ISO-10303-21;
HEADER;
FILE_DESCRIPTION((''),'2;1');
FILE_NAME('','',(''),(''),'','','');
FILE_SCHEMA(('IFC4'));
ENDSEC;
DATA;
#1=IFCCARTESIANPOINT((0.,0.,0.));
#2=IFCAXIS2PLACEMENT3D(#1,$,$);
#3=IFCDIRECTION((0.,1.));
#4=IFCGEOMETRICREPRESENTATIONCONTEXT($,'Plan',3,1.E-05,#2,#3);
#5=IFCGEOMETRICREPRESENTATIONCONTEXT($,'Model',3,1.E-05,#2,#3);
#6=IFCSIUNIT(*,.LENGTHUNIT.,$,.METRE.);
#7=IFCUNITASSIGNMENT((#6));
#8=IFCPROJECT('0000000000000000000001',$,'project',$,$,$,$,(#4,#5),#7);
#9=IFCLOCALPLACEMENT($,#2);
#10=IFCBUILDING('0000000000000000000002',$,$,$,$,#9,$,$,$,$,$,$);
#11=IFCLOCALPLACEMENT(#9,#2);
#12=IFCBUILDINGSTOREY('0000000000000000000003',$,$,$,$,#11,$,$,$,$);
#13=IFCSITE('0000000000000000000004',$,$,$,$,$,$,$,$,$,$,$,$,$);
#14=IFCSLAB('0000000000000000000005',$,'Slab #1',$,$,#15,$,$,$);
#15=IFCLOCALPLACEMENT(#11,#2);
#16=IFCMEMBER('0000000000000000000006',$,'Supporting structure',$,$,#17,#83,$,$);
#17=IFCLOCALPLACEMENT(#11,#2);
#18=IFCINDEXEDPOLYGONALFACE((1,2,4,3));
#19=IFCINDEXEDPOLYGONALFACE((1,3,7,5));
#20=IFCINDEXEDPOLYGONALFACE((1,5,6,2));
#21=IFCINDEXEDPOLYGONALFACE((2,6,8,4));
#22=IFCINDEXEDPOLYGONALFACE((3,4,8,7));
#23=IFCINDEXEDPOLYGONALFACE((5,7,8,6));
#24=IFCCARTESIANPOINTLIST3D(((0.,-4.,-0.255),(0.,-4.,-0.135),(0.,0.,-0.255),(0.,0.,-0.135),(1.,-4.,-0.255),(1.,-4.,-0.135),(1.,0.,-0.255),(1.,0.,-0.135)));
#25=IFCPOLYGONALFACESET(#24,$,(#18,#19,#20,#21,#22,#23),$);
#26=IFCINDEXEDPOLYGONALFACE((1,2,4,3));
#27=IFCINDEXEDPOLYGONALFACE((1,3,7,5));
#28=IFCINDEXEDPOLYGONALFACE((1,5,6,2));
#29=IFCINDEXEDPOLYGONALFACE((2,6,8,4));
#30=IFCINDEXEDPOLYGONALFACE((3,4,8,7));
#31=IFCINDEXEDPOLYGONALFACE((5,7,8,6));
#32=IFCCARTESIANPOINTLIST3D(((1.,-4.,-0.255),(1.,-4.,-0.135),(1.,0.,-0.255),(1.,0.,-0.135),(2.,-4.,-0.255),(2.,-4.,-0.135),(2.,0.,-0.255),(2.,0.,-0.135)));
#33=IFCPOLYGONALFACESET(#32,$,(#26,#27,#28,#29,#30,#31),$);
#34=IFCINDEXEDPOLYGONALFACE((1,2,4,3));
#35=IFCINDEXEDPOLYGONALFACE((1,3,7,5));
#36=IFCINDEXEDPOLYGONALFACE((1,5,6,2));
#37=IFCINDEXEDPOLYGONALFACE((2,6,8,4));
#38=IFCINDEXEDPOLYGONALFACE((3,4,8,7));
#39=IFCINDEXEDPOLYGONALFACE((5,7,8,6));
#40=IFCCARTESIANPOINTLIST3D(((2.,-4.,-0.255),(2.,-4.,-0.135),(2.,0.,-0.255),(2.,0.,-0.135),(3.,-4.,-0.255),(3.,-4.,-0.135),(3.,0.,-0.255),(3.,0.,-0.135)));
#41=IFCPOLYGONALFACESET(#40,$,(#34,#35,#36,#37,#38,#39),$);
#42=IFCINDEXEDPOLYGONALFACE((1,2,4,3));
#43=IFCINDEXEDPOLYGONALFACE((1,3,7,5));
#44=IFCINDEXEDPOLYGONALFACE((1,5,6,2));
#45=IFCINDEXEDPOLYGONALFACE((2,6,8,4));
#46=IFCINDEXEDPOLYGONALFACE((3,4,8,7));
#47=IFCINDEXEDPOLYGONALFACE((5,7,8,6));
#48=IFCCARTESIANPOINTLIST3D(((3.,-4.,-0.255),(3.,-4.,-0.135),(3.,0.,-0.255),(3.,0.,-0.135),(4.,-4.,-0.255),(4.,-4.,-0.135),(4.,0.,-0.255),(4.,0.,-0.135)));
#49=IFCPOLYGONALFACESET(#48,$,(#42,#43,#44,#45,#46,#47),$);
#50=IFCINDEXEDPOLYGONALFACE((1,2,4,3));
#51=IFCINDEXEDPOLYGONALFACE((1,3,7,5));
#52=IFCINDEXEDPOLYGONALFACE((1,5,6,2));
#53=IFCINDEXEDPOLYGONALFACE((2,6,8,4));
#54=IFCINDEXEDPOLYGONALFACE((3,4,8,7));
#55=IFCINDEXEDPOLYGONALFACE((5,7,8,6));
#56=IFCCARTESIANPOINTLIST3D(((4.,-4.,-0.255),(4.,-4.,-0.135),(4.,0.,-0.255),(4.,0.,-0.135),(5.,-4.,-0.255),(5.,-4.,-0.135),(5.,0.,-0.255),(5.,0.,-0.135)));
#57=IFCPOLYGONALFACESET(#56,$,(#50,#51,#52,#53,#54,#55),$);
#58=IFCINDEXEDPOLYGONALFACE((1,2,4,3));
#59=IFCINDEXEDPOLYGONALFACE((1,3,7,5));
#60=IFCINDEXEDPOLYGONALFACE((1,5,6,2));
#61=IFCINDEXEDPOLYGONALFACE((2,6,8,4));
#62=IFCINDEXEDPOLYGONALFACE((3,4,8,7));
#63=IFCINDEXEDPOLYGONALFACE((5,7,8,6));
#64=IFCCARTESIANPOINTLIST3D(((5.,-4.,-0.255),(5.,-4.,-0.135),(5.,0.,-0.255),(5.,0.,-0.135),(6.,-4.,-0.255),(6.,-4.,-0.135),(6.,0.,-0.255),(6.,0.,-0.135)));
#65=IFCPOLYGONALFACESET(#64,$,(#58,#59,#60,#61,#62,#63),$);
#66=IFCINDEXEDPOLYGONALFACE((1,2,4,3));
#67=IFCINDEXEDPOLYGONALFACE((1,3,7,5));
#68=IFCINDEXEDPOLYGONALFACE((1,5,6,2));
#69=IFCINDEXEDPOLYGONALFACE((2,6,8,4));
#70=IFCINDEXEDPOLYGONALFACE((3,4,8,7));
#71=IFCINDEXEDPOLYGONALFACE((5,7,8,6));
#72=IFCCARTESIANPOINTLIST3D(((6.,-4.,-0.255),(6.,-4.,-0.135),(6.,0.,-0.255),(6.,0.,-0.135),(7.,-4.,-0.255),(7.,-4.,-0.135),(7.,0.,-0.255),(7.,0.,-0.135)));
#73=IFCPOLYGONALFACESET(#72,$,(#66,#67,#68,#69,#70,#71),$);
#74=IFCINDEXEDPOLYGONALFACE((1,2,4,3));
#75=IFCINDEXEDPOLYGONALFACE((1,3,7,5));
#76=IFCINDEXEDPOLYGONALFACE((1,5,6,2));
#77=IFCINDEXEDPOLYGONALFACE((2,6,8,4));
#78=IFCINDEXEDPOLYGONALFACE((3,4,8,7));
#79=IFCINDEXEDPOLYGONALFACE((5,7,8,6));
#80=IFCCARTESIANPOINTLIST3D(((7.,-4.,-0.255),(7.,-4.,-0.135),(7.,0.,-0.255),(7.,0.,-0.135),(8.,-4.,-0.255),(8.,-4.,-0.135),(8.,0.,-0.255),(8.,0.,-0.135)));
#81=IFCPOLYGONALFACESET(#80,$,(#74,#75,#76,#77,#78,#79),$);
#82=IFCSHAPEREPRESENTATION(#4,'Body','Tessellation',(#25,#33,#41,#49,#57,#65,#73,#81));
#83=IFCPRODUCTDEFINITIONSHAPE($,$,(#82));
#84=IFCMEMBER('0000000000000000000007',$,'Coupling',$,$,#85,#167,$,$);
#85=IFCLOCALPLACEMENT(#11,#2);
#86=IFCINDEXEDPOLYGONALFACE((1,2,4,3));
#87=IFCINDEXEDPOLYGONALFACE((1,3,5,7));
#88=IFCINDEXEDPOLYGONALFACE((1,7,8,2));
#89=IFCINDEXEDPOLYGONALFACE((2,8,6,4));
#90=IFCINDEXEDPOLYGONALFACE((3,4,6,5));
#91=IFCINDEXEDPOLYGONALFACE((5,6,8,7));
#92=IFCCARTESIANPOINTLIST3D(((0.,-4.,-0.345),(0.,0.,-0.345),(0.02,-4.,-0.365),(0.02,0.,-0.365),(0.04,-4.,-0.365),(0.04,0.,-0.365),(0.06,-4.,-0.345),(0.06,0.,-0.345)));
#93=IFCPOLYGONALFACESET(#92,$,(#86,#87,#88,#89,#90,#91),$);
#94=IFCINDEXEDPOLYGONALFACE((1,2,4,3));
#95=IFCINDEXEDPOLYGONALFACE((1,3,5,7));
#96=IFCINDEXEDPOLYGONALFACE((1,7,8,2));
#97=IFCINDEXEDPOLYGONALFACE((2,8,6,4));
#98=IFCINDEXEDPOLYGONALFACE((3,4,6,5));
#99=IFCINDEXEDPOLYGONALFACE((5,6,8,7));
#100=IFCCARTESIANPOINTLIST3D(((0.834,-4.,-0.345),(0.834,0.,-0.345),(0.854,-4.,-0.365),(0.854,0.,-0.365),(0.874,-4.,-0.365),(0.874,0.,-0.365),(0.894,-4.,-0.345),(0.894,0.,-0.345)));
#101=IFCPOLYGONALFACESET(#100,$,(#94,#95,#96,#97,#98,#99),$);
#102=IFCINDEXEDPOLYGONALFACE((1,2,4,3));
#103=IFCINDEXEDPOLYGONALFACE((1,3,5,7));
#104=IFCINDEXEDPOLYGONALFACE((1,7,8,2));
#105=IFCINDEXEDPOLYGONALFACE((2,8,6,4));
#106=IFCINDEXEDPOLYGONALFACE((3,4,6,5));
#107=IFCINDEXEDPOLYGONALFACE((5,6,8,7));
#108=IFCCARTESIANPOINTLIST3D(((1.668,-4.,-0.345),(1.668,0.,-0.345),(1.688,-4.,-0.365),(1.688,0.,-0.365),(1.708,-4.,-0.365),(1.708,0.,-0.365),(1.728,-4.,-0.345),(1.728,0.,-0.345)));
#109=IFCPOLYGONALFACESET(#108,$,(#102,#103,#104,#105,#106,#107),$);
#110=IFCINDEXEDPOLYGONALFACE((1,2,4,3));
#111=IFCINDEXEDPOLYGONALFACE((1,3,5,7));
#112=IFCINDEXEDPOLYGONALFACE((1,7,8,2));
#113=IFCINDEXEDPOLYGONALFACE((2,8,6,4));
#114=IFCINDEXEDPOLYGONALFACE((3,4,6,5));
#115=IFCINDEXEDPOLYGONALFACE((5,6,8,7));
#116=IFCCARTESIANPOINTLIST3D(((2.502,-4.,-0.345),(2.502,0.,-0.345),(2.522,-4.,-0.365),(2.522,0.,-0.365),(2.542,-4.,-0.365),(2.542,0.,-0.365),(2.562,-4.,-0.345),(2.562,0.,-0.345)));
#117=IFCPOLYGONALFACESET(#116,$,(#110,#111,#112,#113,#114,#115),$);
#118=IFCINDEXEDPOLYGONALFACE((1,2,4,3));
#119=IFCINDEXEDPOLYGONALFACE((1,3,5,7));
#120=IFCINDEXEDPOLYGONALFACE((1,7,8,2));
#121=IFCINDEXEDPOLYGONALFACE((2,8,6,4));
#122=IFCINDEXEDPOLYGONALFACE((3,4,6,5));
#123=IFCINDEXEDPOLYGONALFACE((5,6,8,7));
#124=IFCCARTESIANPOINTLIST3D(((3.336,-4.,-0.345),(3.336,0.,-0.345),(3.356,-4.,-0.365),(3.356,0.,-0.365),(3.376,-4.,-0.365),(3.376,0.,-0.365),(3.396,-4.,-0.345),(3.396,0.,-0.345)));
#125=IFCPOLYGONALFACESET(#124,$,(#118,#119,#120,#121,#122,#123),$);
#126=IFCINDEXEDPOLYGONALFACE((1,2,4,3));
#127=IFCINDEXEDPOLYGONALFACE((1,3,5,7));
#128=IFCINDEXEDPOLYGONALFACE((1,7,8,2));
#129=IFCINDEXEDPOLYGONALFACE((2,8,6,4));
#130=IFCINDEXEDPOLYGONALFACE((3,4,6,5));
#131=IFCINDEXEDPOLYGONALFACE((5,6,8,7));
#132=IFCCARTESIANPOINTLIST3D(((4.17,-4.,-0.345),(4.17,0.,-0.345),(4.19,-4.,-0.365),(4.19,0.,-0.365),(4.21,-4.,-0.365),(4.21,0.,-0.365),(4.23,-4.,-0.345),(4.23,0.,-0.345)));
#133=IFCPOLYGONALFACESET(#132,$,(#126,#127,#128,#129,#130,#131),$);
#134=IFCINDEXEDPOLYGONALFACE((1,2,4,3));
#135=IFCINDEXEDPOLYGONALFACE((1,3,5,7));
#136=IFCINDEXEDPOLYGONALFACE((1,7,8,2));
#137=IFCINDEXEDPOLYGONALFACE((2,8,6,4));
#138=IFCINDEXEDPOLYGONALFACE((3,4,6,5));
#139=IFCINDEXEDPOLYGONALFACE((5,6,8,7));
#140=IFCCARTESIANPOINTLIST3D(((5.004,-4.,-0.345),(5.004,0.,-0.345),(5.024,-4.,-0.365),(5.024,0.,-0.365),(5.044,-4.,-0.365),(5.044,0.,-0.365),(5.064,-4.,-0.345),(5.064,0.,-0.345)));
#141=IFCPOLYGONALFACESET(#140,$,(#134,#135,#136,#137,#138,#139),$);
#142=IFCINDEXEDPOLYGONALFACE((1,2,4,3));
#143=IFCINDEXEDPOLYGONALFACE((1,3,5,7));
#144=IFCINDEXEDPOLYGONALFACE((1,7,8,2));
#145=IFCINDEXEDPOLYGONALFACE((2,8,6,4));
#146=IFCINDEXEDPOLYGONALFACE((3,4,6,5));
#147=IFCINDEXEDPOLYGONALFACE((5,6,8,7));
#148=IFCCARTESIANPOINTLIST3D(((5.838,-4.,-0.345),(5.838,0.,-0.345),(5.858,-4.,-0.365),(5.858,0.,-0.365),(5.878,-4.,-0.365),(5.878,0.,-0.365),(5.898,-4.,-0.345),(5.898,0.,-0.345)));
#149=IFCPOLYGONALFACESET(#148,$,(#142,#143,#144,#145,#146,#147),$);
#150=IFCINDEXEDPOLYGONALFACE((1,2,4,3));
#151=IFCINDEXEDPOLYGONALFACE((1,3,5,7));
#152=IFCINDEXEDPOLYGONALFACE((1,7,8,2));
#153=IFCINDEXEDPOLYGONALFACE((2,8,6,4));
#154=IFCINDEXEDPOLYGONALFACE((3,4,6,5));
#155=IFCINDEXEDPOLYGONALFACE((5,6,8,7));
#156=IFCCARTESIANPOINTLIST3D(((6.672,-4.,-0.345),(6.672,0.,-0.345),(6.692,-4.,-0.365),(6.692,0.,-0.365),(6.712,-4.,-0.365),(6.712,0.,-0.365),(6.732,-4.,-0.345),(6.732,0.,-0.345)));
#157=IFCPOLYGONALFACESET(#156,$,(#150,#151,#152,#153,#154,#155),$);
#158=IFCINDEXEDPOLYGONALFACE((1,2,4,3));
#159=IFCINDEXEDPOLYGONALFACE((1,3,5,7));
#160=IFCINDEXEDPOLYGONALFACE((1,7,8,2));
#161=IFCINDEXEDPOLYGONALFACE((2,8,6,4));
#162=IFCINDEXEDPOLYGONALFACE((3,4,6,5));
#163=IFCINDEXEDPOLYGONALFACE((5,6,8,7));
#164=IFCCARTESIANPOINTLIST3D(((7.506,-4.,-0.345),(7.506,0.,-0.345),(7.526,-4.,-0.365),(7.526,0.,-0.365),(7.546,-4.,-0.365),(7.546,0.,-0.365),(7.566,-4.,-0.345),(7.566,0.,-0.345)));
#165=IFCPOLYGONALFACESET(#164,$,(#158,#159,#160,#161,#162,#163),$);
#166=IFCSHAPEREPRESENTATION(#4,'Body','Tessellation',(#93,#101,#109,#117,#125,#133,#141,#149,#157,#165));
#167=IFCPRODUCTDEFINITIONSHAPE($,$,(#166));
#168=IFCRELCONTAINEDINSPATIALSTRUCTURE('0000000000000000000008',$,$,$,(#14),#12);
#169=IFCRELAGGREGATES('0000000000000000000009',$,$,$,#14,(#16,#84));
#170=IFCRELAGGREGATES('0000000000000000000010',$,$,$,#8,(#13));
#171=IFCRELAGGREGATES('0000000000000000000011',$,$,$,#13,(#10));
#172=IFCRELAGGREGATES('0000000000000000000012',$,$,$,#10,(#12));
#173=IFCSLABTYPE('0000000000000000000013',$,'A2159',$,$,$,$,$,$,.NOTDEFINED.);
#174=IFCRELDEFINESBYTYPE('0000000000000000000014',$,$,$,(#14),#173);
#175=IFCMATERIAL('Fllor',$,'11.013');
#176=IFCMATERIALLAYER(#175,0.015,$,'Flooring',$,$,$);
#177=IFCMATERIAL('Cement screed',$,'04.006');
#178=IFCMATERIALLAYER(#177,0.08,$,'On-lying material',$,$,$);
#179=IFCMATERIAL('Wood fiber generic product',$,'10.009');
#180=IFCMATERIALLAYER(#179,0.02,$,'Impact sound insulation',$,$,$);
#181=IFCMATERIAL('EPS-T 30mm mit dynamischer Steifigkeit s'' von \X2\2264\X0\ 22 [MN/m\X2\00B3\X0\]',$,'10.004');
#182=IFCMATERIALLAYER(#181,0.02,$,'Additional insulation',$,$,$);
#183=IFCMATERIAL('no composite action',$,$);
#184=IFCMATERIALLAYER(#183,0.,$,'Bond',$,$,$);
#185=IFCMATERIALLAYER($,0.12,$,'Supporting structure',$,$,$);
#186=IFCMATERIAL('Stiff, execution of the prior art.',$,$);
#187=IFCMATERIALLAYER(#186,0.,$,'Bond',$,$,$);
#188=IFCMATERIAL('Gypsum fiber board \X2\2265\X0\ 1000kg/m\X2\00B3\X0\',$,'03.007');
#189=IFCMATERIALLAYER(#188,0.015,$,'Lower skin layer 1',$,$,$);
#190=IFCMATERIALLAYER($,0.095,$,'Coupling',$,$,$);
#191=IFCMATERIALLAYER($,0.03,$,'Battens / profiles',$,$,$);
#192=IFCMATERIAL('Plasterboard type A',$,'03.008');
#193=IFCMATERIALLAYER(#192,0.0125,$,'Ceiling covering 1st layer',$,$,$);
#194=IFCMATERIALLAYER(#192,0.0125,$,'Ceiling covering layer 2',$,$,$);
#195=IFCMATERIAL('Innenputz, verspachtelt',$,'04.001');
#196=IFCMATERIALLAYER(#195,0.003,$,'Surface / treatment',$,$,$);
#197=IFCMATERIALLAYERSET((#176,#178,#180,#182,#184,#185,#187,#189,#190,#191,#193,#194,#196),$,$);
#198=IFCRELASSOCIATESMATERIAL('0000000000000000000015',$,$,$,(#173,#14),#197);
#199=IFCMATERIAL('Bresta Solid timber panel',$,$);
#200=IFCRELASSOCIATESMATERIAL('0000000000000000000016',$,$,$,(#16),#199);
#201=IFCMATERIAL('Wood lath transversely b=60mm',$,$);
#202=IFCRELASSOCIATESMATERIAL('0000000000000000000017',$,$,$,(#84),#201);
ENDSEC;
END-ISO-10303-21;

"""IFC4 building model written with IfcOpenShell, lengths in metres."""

from ifc_helpers import new_model, si_unit, direction, frame, frame_2d, origin, place, context, project, spatial, polyline, rectangle, outline, extrude, material, layer, layer_set, type_object, element, aggregate, save


model = new_model("IFC4")

# Units and contexts
plan_context = context("Plan", 3, precision=1e-05, world=origin(), true_north=direction((0.0, 1.0)))
model_context = context("Model", 3, precision=1e-05, world=origin(), true_north=direction((0.0, 1.0)))
ifc_project = project(units=[si_unit("LENGTHUNIT", "METRE")], contexts=[plan_context, model_context])

# Site, building, storey
site = spatial("IfcSite", under=ifc_project)
building_placement = place(None, origin())
building = spatial("IfcBuilding", under=site, at=building_placement)
storey_placement = place(building_placement, origin())
storey = spatial("IfcBuildingStorey", under=building, at=storey_placement)

# Slab, members
ifc_material_1 = material(Name="Fllor", Category="11.013")
ifc_layer_1 = layer(ifc_material_1, 0.015, Name="Flooring")
ifc_material_2 = material(Name="Cement screed", Category="04.006")
ifc_layer_2 = layer(ifc_material_2, 0.08, Name="On-lying material")
ifc_material_3 = material(Name="Wood fiber generic product", Category="10.009")
ifc_layer_3 = layer(ifc_material_3, 0.02, Name="Impact sound insulation")
ifc_material_4 = material(Name="EPS-T 30mm mit dynamischer Steifigkeit s' von ≤ 22 [MN/m³]", Category="10.004")
ifc_layer_4 = layer(ifc_material_4, 0.02, Name="Additional insulation")
ifc_material_5 = material(Name="no composite action")
ifc_layer_5 = layer(ifc_material_5, 0.0, Name="Bond")
ifc_layer_6 = layer(None, 0.12, Name="Supporting structure")
ifc_material_6 = material(Name="Stiff, execution of the prior art.")
ifc_layer_7 = layer(ifc_material_6, 0.0, Name="Bond")
ifc_material_7 = material(Name="Gypsum fiber board ≥ 1000kg/m³", Category="03.007")
ifc_layer_8 = layer(ifc_material_7, 0.015, Name="Lower skin layer 1")
ifc_layer_9 = layer(None, 0.095, Name="Coupling")
ifc_layer_10 = layer(None, 0.03, Name="Battens / profiles")
ifc_material_8 = material(Name="Plasterboard type A", Category="03.008")
ifc_layer_11 = layer(ifc_material_8, 0.0125, Name="Ceiling covering 1st layer")
ifc_layer_12 = layer(ifc_material_8, 0.0125, Name="Ceiling covering layer 2")
ifc_material_9 = material(Name="Innenputz, verspachtelt", Category="04.001")
ifc_layer_13 = layer(ifc_material_9, 0.003, Name="Surface / treatment")
ifc_layer_set = layer_set([ifc_layer_1, ifc_layer_2, ifc_layer_3, ifc_layer_4, ifc_layer_5, ifc_layer_6, ifc_layer_7, ifc_layer_8, ifc_layer_9, ifc_layer_10, ifc_layer_11, ifc_layer_12, ifc_layer_13])
slab_type = type_object("IfcSlabType", Name="A2159", PredefinedType="NOTDEFINED", material=ifc_layer_set)
slab_placement = place(None, frame((0.0, 0.0, 0.0), z_axis=(0.0, 0.0, -1.0), x_axis=(1.0, 0.0, 0.0)))
slab = element("IfcSlab", 1, at=slab_placement, inside=storey, type_object=slab_type, material=ifc_layer_set, Name="Slab #1")
ifc_material_10 = material(Name="Bresta Solid timber panel")
member_1_placement = place(slab_placement, origin())
member_1 = element("IfcMember", 2, at=member_1_placement, material=ifc_material_10, Name="Supporting structure", context=plan_context, shape_type="SweptSolid", body=[
    extrude(rectangle(XDim=1.0, YDim=0.12, at=frame_2d((0.5, 0.06), x_axis=(1.0, 0.0))), frame((0.0, 4.0, 0.135), z_axis=(0.0, -1.0, 0.0), x_axis=(1.0, 0.0, 0.0)), (0.0, 0.0, 1.0), 4.0),
    extrude(rectangle(XDim=1.0, YDim=0.12, at=frame_2d((0.5, 0.06), x_axis=(1.0, 0.0))), frame((1.0, 4.0, 0.135), z_axis=(0.0, -1.0, 0.0), x_axis=(1.0, 0.0, 0.0)), (0.0, 0.0, 1.0), 4.0),
    extrude(rectangle(XDim=1.0, YDim=0.12, at=frame_2d((0.5, 0.06), x_axis=(1.0, 0.0))), frame((2.0, 4.0, 0.135), z_axis=(0.0, -1.0, 0.0), x_axis=(1.0, 0.0, 0.0)), (0.0, 0.0, 1.0), 4.0),
    extrude(rectangle(XDim=1.0, YDim=0.12, at=frame_2d((0.5, 0.06), x_axis=(1.0, 0.0))), frame((3.0, 4.0, 0.135), z_axis=(0.0, -1.0, 0.0), x_axis=(1.0, 0.0, 0.0)), (0.0, 0.0, 1.0), 4.0),
    extrude(rectangle(XDim=1.0, YDim=0.12, at=frame_2d((0.5, 0.06), x_axis=(1.0, 0.0))), frame((4.0, 4.0, 0.135), z_axis=(0.0, -1.0, 0.0), x_axis=(1.0, 0.0, 0.0)), (0.0, 0.0, 1.0), 4.0),
    extrude(rectangle(XDim=1.0, YDim=0.12, at=frame_2d((0.5, 0.06), x_axis=(1.0, 0.0))), frame((5.0, 4.0, 0.135), z_axis=(0.0, -1.0, 0.0), x_axis=(1.0, 0.0, 0.0)), (0.0, 0.0, 1.0), 4.0),
    extrude(rectangle(XDim=1.0, YDim=0.12, at=frame_2d((0.5, 0.06), x_axis=(1.0, 0.0))), frame((6.0, 4.0, 0.135), z_axis=(0.0, -1.0, 0.0), x_axis=(1.0, 0.0, 0.0)), (0.0, 0.0, 1.0), 4.0),
    extrude(rectangle(XDim=1.0, YDim=0.12, at=frame_2d((0.5, 0.06), x_axis=(1.0, 0.0))), frame((7.0, 4.0, 0.135), z_axis=(0.0, -1.0, 0.0), x_axis=(1.0, 0.0, 0.0)), (0.0, 0.0, 1.0), 4.0),
])
ifc_material_11 = material(Name="Wood lath transversely b=60mm")
member_2_placement = place(slab_placement, origin())
member_2 = element("IfcMember", 3, at=member_2_placement, material=ifc_material_11, Name="Coupling", context=plan_context, shape_type="SweptSolid", body=[
    extrude(outline(polyline([(0.0, 0.0), (0.06, 0.0), (0.04, 0.02), (0.02, 0.02), (0.0, 0.0)])), frame((0.0, 4.0, 0.345), z_axis=(0.0, -1.0, 0.0), x_axis=(1.0, 0.0, 0.0)), (0.0, 0.0, 1.0), 4.0),
    extrude(outline(polyline([(0.0, 0.0), (0.06, 0.0), (0.04, 0.02), (0.02, 0.02), (0.0, 0.0)])), frame((0.834, 4.0, 0.345), z_axis=(0.0, -1.0, 0.0), x_axis=(1.0, 0.0, 0.0)), (0.0, 0.0, 1.0), 4.0),
    extrude(outline(polyline([(0.0, 0.0), (0.06, 0.0), (0.04, 0.02), (0.02, 0.02), (0.0, 0.0)])), frame((1.668, 4.0, 0.345), z_axis=(0.0, -1.0, 0.0), x_axis=(1.0, 0.0, 0.0)), (0.0, 0.0, 1.0), 4.0),
    extrude(outline(polyline([(0.0, 0.0), (0.06, 0.0), (0.04, 0.02), (0.02, 0.02), (0.0, 0.0)])), frame((2.502, 4.0, 0.345), z_axis=(0.0, -1.0, 0.0), x_axis=(1.0, 0.0, 0.0)), (0.0, 0.0, 1.0), 4.0),
    extrude(outline(polyline([(0.0, 0.0), (0.06, 0.0), (0.04, 0.02), (0.02, 0.02), (0.0, 0.0)])), frame((3.336, 4.0, 0.345), z_axis=(0.0, -1.0, 0.0), x_axis=(1.0, 0.0, 0.0)), (0.0, 0.0, 1.0), 4.0),
    extrude(outline(polyline([(0.0, 0.0), (0.06, 0.0), (0.04, 0.02), (0.02, 0.02), (0.0, 0.0)])), frame((4.17, 4.0, 0.345), z_axis=(0.0, -1.0, 0.0), x_axis=(1.0, 0.0, 0.0)), (0.0, 0.0, 1.0), 4.0),
    extrude(outline(polyline([(0.0, 0.0), (0.06, 0.0), (0.04, 0.02), (0.02, 0.02), (0.0, 0.0)])), frame((5.004, 4.0, 0.345), z_axis=(0.0, -1.0, 0.0), x_axis=(1.0, 0.0, 0.0)), (0.0, 0.0, 1.0), 4.0),
    extrude(outline(polyline([(0.0, 0.0), (0.06, 0.0), (0.04, 0.02), (0.02, 0.02), (0.0, 0.0)])), frame((5.838, 4.0, 0.345), z_axis=(0.0, -1.0, 0.0), x_axis=(1.0, 0.0, 0.0)), (0.0, 0.0, 1.0), 4.0),
    extrude(outline(polyline([(0.0, 0.0), (0.06, 0.0), (0.04, 0.02), (0.02, 0.02), (0.0, 0.0)])), frame((6.672, 4.0, 0.345), z_axis=(0.0, -1.0, 0.0), x_axis=(1.0, 0.0, 0.0)), (0.0, 0.0, 1.0), 4.0),
    extrude(outline(polyline([(0.0, 0.0), (0.06, 0.0), (0.04, 0.02), (0.02, 0.02), (0.0, 0.0)])), frame((7.506, 4.0, 0.345), z_axis=(0.0, -1.0, 0.0), x_axis=(1.0, 0.0, 0.0)), (0.0, 0.0, 1.0), 4.0),
])
aggregate(slab, [member_1, member_2])

save(model, "model.ifc")
